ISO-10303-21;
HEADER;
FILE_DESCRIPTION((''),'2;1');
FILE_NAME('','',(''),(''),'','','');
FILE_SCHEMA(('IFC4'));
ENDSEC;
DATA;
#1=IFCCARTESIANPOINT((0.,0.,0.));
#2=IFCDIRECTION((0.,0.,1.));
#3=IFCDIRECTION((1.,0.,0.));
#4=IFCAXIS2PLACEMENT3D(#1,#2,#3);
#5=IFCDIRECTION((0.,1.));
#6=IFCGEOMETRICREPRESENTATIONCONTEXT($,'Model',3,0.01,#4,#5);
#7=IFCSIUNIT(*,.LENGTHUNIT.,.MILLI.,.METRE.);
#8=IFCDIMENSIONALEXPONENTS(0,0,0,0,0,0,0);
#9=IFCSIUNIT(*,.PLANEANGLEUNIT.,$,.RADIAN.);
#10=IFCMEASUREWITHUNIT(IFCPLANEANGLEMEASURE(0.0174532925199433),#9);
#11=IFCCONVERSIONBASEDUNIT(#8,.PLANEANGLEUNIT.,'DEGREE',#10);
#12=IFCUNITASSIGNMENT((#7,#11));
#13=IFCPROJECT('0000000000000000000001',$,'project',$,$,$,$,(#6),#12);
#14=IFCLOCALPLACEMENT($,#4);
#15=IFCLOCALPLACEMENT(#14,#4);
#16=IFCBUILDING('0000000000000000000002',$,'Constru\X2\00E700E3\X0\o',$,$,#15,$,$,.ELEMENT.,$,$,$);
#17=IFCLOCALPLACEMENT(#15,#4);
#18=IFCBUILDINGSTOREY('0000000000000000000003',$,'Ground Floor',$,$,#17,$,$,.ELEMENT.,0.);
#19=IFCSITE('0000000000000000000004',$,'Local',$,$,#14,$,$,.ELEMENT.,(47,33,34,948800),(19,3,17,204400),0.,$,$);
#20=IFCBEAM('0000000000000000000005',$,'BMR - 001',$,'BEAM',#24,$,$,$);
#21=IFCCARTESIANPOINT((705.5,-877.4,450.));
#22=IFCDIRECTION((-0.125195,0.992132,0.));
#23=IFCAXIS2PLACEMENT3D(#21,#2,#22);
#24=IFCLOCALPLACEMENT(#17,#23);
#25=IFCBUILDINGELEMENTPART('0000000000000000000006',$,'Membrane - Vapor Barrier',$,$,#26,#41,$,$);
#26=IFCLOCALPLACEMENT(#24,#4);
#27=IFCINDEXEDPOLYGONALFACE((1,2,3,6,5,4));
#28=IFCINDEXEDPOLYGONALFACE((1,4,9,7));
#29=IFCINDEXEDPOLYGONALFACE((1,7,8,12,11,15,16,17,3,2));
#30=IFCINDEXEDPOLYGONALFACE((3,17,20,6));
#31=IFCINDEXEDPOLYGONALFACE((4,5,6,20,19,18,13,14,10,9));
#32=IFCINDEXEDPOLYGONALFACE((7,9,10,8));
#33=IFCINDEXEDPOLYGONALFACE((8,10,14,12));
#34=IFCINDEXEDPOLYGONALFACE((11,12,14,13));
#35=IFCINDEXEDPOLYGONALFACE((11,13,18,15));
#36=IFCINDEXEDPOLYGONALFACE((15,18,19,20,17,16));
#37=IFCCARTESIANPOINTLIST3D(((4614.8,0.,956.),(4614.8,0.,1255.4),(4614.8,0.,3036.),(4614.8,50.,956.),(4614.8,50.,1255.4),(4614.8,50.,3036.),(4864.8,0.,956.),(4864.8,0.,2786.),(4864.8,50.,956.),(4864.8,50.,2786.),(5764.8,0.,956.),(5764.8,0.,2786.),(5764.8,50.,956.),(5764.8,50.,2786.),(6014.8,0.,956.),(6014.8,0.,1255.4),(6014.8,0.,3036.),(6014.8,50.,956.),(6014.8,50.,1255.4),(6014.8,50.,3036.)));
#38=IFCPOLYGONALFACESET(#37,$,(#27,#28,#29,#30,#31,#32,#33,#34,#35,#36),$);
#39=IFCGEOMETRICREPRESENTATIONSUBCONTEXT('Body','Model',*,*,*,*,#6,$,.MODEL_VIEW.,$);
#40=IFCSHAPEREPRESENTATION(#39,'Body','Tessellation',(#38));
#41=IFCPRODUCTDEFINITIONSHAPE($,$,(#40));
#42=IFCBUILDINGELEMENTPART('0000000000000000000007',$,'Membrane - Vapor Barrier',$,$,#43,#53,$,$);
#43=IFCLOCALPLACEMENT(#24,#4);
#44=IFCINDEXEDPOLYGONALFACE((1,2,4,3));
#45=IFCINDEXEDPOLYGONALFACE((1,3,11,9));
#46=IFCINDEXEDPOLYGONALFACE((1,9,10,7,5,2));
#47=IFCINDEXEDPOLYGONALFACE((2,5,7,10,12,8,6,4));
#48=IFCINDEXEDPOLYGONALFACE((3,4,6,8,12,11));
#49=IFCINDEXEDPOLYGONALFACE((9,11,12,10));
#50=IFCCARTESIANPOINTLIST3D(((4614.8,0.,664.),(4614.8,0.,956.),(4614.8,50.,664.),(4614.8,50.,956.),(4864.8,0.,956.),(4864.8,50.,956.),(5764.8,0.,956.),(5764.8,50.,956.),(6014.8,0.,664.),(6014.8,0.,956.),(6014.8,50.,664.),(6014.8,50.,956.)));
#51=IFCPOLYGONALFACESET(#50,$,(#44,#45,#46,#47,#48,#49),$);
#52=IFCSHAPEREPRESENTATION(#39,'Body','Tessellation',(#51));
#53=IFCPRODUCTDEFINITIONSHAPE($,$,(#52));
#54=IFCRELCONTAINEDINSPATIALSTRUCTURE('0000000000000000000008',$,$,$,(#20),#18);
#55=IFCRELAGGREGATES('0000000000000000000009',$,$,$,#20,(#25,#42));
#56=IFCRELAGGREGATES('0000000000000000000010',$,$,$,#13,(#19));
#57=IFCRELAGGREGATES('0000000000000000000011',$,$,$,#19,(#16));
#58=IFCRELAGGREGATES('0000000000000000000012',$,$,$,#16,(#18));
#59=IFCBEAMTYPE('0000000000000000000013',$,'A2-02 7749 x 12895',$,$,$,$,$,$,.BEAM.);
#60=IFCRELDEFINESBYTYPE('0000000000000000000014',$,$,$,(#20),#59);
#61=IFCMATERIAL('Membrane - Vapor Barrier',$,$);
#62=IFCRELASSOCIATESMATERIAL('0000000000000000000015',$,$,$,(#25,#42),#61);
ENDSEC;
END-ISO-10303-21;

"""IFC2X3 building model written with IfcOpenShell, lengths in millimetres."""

from ifc_helpers import new_model, entity, si_unit, converted_unit, direction, frame, origin_with_axes, place, context, subcontext, project, spatial, polyline, outline, extrude, material, type_object, element, aggregate, save


model = new_model("IFC2X3")

# Units and contexts
model_context = context("Model", 3, precision=0.01, world=origin_with_axes(), true_north=direction((0.0, 1.0)))
body_context = subcontext(model_context, "Body", "Model", "MODEL_VIEW")
ifc_project = project(units=[si_unit("LENGTHUNIT", "METRE", prefix="MILLI"), converted_unit("PLANEANGLEUNIT", "DEGREE", entity("IfcPlaneAngleMeasure", 0.0174532925199433), si_unit("PLANEANGLEUNIT", "RADIAN"), dimensions=[0, 0, 0, 0, 0, 0, 0])], contexts=[model_context])

# Site, building, storey
site_placement = place(None, origin_with_axes())
site = spatial("IfcSite", under=ifc_project, at=site_placement, Name="Local", CompositionType="ELEMENT", RefLatitude=(47, 33, 34, 948800), RefLongitude=(19, 3, 17, 204400), RefElevation=0.0)
building_placement = place(site_placement, origin_with_axes())
building = spatial("IfcBuilding", under=site, at=building_placement, Name="Construção", CompositionType="ELEMENT")
storey_placement = place(building_placement, origin_with_axes())
storey = spatial("IfcBuildingStorey", under=building, at=storey_placement, Name="Ground Floor", CompositionType="ELEMENT", Elevation=0.0)

# Shared definitions
ifc_material_1 = material(Name="Membrane - Vapor Barrier")

# Beam, building element parts
beam_type_1 = type_object("IfcBeamType", Name="A2-02 7749 x 12895", PredefinedType="BEAM")
beam_1_placement = place(storey_placement, frame((705.5, -877.4, 450.0), z_axis=(0.0, 0.0, 1.0), x_axis=(-0.125195, 0.992132, 0.0)))
beam_1 = element("IfcBeam", 1, at=beam_1_placement, inside=storey, type_object=beam_type_1, Name="BMR - 001", ObjectType="BEAM")
building_element_part_1_placement = place(beam_1_placement, origin_with_axes())
building_element_part_1 = element("IfcBuildingElementPart", 2, at=building_element_part_1_placement, material=ifc_material_1, Name="Membrane - Vapor Barrier", context=body_context, shape_type="SweptSolid", body=[
    extrude(outline(polyline([(6014.8, 3036.0), (4614.8, 3036.0), (4614.8, 1255.4), (4614.8, 956.0), (4864.8, 956.0), (4864.8, 2786.0), (5764.8, 2786.0), (5764.8, 956.0), (6014.8, 956.0), (6014.8, 1255.4), (6014.8, 3036.0)])), frame((0.0, 50.0, 0.0), z_axis=(0.0, -1.0, 0.0), x_axis=(1.0, 0.0, 0.0)), (0.0, 0.0, 1.0), 50.0),
])
building_element_part_2_placement = place(beam_1_placement, origin_with_axes())
building_element_part_2 = element("IfcBuildingElementPart", 3, at=building_element_part_2_placement, material=ifc_material_1, Name="Membrane - Vapor Barrier", context=body_context, shape_type="SweptSolid", body=[
    extrude(outline(polyline([(4614.8, 664.0), (6014.8, 664.0), (6014.8, 956.0), (5764.8, 956.0), (4864.8, 956.0), (4614.8, 956.0), (4614.8, 664.0)])), frame((0.0, 50.0, 0.0), z_axis=(0.0, -1.0, 0.0), x_axis=(1.0, 0.0, 0.0)), (0.0, 0.0, 1.0), 50.0),
])
aggregate(beam_1, [building_element_part_1, building_element_part_2])

save(model, "model.ifc")
